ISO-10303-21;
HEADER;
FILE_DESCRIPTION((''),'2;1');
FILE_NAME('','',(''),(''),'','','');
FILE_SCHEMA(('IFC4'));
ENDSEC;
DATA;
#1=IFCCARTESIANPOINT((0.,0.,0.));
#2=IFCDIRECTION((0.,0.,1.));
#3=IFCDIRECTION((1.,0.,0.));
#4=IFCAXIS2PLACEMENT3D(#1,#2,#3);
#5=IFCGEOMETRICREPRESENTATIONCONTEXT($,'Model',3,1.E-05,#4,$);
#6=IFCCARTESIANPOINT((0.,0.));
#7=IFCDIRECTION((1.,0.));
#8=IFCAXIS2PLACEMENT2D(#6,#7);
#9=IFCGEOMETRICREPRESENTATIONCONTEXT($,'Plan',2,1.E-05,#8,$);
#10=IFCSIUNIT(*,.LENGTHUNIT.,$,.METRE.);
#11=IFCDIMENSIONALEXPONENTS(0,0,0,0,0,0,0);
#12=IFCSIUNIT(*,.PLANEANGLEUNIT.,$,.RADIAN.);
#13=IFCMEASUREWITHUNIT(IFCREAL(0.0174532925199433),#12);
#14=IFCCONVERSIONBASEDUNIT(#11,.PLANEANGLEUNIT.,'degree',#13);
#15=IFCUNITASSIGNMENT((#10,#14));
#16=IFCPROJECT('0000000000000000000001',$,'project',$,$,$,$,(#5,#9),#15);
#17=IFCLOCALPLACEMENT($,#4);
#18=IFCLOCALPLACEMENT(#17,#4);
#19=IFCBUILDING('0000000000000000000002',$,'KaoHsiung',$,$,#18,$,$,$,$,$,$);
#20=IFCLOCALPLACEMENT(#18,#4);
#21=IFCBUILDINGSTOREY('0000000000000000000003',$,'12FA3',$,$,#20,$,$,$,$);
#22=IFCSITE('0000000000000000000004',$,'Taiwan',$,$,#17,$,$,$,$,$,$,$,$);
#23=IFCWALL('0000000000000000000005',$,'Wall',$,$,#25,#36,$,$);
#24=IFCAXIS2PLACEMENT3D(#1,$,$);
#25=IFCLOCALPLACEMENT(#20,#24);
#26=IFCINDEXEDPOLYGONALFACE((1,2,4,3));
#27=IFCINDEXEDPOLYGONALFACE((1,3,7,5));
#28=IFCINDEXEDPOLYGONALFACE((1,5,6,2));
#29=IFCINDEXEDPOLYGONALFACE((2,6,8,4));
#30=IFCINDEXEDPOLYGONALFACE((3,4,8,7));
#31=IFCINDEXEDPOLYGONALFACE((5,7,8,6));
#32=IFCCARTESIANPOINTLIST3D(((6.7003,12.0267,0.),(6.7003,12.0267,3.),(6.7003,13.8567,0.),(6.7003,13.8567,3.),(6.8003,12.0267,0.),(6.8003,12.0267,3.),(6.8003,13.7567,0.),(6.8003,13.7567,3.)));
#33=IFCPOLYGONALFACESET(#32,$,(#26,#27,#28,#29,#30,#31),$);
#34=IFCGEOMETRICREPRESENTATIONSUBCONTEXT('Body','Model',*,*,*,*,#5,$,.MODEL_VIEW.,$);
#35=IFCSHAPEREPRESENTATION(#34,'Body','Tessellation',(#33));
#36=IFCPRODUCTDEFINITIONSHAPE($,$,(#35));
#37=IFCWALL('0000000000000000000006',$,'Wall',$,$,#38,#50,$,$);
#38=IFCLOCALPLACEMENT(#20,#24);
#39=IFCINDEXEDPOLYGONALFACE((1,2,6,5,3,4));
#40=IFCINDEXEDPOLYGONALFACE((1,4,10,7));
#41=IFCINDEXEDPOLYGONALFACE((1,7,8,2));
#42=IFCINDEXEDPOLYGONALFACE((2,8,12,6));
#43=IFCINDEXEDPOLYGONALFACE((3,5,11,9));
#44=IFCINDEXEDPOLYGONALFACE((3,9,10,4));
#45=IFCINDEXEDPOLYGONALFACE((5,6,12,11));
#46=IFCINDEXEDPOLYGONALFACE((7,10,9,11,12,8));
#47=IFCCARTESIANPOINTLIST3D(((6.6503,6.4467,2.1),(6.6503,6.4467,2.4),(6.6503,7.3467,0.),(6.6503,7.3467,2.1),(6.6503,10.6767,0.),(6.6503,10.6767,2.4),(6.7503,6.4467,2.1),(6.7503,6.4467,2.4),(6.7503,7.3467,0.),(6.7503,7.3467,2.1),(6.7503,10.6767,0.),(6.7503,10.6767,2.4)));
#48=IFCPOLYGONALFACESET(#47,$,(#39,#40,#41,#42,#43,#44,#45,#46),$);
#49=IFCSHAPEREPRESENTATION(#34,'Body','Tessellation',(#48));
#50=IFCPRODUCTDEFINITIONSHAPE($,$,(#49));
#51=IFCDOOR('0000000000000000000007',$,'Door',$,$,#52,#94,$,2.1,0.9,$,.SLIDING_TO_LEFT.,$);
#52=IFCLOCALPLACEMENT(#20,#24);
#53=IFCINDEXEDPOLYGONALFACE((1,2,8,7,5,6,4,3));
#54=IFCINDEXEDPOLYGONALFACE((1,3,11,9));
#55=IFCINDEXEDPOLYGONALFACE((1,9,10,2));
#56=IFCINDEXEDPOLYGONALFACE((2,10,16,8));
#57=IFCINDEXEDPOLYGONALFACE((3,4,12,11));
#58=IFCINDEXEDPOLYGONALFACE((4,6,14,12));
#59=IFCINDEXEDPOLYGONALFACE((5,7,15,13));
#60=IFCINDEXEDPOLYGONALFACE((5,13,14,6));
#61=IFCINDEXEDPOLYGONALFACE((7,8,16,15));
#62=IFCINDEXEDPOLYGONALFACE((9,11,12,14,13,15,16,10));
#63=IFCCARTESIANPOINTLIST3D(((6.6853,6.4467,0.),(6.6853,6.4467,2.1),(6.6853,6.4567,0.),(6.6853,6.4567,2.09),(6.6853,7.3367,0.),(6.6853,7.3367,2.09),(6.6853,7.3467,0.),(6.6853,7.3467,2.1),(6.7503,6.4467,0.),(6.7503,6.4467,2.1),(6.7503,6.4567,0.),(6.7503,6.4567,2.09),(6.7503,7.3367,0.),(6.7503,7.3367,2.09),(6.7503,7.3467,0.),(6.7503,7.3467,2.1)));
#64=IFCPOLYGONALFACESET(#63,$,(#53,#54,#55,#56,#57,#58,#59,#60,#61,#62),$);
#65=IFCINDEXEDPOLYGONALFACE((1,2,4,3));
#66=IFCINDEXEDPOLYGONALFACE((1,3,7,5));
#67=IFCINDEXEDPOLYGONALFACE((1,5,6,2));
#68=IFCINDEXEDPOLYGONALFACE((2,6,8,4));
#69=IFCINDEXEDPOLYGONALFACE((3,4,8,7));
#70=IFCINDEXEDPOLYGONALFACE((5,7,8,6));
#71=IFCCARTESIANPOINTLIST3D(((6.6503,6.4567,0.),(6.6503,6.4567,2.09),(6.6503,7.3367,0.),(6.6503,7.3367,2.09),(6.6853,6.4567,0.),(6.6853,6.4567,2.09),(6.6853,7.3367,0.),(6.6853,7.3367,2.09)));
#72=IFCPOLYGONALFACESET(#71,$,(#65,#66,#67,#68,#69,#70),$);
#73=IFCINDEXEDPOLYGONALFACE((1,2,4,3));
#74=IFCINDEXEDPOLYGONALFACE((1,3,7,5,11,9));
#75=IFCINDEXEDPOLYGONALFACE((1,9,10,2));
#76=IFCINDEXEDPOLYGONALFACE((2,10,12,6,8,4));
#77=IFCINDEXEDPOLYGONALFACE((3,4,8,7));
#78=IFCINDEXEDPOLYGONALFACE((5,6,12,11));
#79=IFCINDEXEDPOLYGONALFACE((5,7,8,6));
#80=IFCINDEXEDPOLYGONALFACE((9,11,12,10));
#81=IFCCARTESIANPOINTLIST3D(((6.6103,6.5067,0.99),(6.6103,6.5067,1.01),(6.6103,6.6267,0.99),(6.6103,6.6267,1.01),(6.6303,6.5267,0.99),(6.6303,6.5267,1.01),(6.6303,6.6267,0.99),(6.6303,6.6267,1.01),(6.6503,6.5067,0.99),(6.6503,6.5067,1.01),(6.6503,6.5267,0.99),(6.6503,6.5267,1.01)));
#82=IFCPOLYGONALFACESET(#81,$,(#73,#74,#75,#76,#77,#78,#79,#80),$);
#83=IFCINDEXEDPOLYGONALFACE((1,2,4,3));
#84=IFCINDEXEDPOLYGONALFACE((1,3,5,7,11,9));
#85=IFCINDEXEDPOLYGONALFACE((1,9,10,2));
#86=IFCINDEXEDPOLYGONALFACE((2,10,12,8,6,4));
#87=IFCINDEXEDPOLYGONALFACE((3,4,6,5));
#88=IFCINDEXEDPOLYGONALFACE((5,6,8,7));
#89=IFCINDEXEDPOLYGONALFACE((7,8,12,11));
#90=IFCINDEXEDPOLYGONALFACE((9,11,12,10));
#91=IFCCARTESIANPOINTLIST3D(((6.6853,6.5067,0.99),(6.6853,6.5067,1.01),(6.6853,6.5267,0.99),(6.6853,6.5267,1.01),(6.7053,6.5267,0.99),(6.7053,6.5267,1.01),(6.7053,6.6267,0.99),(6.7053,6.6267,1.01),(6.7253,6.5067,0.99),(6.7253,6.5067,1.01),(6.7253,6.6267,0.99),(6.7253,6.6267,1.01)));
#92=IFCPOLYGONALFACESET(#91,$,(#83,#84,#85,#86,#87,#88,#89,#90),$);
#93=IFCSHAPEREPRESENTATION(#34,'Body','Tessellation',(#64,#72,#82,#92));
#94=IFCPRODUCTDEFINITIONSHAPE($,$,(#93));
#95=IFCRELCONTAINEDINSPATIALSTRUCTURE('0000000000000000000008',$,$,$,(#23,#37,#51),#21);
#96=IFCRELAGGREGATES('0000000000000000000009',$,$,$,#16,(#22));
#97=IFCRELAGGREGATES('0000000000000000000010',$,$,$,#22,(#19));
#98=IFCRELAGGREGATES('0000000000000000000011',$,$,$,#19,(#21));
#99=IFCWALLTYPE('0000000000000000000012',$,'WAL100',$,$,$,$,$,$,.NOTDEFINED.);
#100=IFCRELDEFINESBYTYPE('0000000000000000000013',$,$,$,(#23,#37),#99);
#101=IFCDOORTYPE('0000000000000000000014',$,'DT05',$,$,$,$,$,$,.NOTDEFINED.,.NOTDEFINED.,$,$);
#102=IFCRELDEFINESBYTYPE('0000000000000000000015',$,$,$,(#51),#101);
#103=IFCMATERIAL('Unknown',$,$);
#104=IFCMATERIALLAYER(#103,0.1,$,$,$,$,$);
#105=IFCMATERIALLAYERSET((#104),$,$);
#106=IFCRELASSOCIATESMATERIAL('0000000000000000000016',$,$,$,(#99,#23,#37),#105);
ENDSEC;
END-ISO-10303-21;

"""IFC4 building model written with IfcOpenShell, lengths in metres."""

from ifc_helpers import new_model, entity, si_unit, converted_unit, frame, origin_with_axes, origin_2d_with_axis, place, context, subcontext, project, spatial, line, indexed_curve, outline, extrude, shape, source, transform, mapped, material, layer, layer_set, layer_usage, type_object, type_shapes, element, fill, save


model = new_model("IFC4")

# Units and contexts
model_context = context("Model", 3, precision=1e-05, world=origin_with_axes())
plan_context = context("Plan", 2, precision=1e-05, world=origin_2d_with_axis())
body_context_1 = subcontext(model_context, "Body", "Model", "MODEL_VIEW")
body_context_2 = subcontext(plan_context, "Body", "Plan", "PLAN_VIEW")
ifc_project = project(units=[si_unit("LENGTHUNIT", "METRE"), converted_unit("PLANEANGLEUNIT", "degree", entity("IfcReal", 0.0174532925199433), si_unit("PLANEANGLEUNIT", "RADIAN"), dimensions=[0, 0, 0, 0, 0, 0, 0])], contexts=[model_context, plan_context])

# Site, building, storey
site_placement = place(None, origin_with_axes())
site = spatial("IfcSite", under=ifc_project, at=site_placement, Name="Taiwan")
building_placement = place(site_placement, origin_with_axes())
building = spatial("IfcBuilding", under=site, at=building_placement, Name="KaoHsiung")
storey_placement = place(building_placement, origin_with_axes())
storey = spatial("IfcBuildingStorey", under=building, at=storey_placement, Name="12FA3")

# Shared definitions
ifc_material = material(Name="Unknown")

# Wall
ifc_layer_1 = layer(ifc_material, 0.1)
ifc_layer_set_1 = layer_set([ifc_layer_1])
wall_type_1 = type_object("IfcWallType", Name="WAL100", PredefinedType="NOTDEFINED", material=ifc_layer_set_1)
ifc_layer_usage_1 = layer_usage(ifc_layer_set_1, "AXIS2", "POSITIVE", 0.0)
wall_1_placement = place(storey_placement, frame((6.7003, 13.8567, 0.0), z_axis=(0.0, 0.0, 1.0), x_axis=(0.0, -1.0, 0.0)))
element("IfcWall", 1, at=wall_1_placement, inside=storey, type_object=wall_type_1, material=ifc_layer_usage_1, Name="Wall", context=body_context_1, shape_type="SweptSolid", body=[
    extrude(outline(indexed_curve([(0.0, 0.0), (0.1, 0.1), (1.8299, 0.1), (1.8299, 0.0)], segments=[line(1, 2, 3, 4, 1)])), origin_with_axes(), (0.0, 0.0, 1.0), 3.0),
])

# Wall, opening, door
ifc_layer_usage_2 = layer_usage(ifc_layer_set_1, "AXIS2", "POSITIVE", 0.0)
wall_2_placement = place(storey_placement, frame((6.6503, 10.6767, 0.0), z_axis=(0.0, 0.0, 1.0), x_axis=(0.0, -1.0, 0.0)))
wall_2 = element("IfcWall", 2, at=wall_2_placement, inside=storey, type_object=wall_type_1, material=ifc_layer_usage_2, Name="Wall", context=body_context_1, shape_type="SweptSolid", body=[
    extrude(outline(indexed_curve([(0.0, 0.0), (0.0, 0.1), (4.23, 0.1), (4.23, 0.0)], segments=[line(1, 2, 3, 4, 1)])), origin_with_axes(), (0.0, 0.0, 1.0), 2.4),
])
shared_shape_1 = source(origin_with_axes(), body_context_1, "Body", "SweptSolid", [
    extrude(outline(indexed_curve([(0.0, 0.0), (0.9, 0.0), (0.9, 2.1), (0.0, 2.1)], segments=[line(1, 2, 3, 4, 1)])), frame((0.0, -0.6, 0.0), z_axis=(0.0, -1.0, 0.0), x_axis=(1.0, 0.0, 0.0)), (0.0, 0.0, -1.0), 1.2),
])
opening_1_placement = place(wall_2_placement, frame((3.33, 0.0, 0.0), z_axis=(0.0, 0.0, 1.0), x_axis=(1.0, 0.0, 0.0)))
opening_1 = element("IfcOpeningElement", 3, at=opening_1_placement, cuts=wall_2, PredefinedType="OPENING", context=body_context_1, shape_type="MappedRepresentation", body=[
    mapped(shared_shape_1, transform((0.0, 0.0, 0.0), x_axis=(1.0, 0.0, 0.0), y_axis=(0.0, 1.0, 0.0), z_axis=(0.0, 0.0, 1.0), scale=1.0)),
])
door_type_1 = type_object("IfcDoorType", Name="DT05", OperationType="NOTDEFINED", PredefinedType="NOTDEFINED")
shared_shape_2 = source(origin_with_axes(), body_context_1, "Body", "SweptSolid", [
    extrude(outline(indexed_curve([(0.0, 0.0), (0.0, 2.1), (0.9, 2.1), (0.9, 0.0), (0.89, 0.0), (0.89, 2.09), (0.01, 2.09), (0.01, 0.0)], segments=[line(1, 2, 3, 4, 5, 6, 7, 8, 1)])), frame((0.0, 0.035, 0.0), z_axis=(0.0, -1.0, 0.0), x_axis=(1.0, 0.0, 0.0)), (0.0, 0.0, -1.0), 0.065),
    extrude(outline(indexed_curve([(0.0, 0.0), (0.88, 0.0), (0.88, 0.035), (0.0, 0.035)], segments=[line(1, 2, 3, 4, 1)])), frame((0.01, 0.0, 0.0), z_axis=(0.0, 0.0, 1.0), x_axis=(1.0, 0.0, 0.0)), (0.0, 0.0, 1.0), 2.09),
    extrude(outline(indexed_curve([(0.0, 0.0), (0.0, -0.04), (-0.12, -0.04), (-0.12, -0.02), (-0.02, -0.02), (-0.02, 0.0)], segments=[line(1, 2, 3, 4, 5, 6, 1)])), frame((0.84, 0.0, 0.99), z_axis=(0.0, 0.0, 1.0), x_axis=(1.0, 0.0, 0.0)), (0.0, 0.0, 1.0), 0.02),
    extrude(outline(indexed_curve([(0.0, 0.0), (0.0, 0.04), (-0.12, 0.04), (-0.12, 0.02), (-0.02, 0.02), (-0.02, 0.0)], segments=[line(1, 2, 3, 4, 5, 6, 1)])), frame((0.84, 0.035, 0.99), z_axis=(0.0, 0.0, 1.0), x_axis=(1.0, 0.0, 0.0)), (0.0, 0.0, 1.0), 0.02),
])
shared_shape_3 = source(origin_with_axes(), body_context_2, "Body", "Curve2D", [
    entity("IfcIndexedPolyCurve", entity("IfcCartesianPointList2D", [[0.0, 0.035], [0.01, 0.035], [0.01, 0.1], [0.0, 0.1]]), [entity("IfcLineIndex", [1, 2, 3, 4, 1])]),
    entity("IfcIndexedPolyCurve", entity("IfcCartesianPointList2D", [[0.9, 0.035], [0.89, 0.035], [0.89, 0.1], [0.9, 0.1]]), [entity("IfcLineIndex", [1, 2, 3, 4, 1])]),
    entity("IfcIndexedPolyCurve", entity("IfcCartesianPointList2D", [[-0.43, 0.0], [0.45, 0.0], [0.45, 0.035], [-0.43, 0.035]]), [entity("IfcLineIndex", [1, 2, 3, 4, 1])]),
])
type_shapes(door_type_1, [shared_shape_2, shared_shape_3])
door_1_placement = place(opening_1_placement, frame((0.0, 0.0, 0.0), z_axis=(0.0, 0.0, 1.0), x_axis=(1.0, 0.0, 0.0)))
door_1 = element("IfcDoor", 4, at=door_1_placement, inside=storey, type_object=door_type_1, Name="Door", OperationType="SLIDING_TO_LEFT", OverallHeight=2.1, OverallWidth=0.9, shapes=[
    shape(body_context_1, "Body", "MappedRepresentation", [mapped(shared_shape_2, transform((0.0, 0.0, 0.0), x_axis=(1.0, 0.0, 0.0), y_axis=(0.0, 1.0, 0.0), z_axis=(0.0, 0.0, 1.0), scale=1.0))]),
    shape(body_context_2, "Body", "MappedRepresentation", [mapped(shared_shape_3, transform((0.0, 0.0, 0.0), x_axis=(1.0, 0.0, 0.0), y_axis=(0.0, 1.0, 0.0), z_axis=(0.0, 0.0, 1.0), scale=1.0))]),
])
fill(opening_1, door_1)

save(model, "model.ifc")
